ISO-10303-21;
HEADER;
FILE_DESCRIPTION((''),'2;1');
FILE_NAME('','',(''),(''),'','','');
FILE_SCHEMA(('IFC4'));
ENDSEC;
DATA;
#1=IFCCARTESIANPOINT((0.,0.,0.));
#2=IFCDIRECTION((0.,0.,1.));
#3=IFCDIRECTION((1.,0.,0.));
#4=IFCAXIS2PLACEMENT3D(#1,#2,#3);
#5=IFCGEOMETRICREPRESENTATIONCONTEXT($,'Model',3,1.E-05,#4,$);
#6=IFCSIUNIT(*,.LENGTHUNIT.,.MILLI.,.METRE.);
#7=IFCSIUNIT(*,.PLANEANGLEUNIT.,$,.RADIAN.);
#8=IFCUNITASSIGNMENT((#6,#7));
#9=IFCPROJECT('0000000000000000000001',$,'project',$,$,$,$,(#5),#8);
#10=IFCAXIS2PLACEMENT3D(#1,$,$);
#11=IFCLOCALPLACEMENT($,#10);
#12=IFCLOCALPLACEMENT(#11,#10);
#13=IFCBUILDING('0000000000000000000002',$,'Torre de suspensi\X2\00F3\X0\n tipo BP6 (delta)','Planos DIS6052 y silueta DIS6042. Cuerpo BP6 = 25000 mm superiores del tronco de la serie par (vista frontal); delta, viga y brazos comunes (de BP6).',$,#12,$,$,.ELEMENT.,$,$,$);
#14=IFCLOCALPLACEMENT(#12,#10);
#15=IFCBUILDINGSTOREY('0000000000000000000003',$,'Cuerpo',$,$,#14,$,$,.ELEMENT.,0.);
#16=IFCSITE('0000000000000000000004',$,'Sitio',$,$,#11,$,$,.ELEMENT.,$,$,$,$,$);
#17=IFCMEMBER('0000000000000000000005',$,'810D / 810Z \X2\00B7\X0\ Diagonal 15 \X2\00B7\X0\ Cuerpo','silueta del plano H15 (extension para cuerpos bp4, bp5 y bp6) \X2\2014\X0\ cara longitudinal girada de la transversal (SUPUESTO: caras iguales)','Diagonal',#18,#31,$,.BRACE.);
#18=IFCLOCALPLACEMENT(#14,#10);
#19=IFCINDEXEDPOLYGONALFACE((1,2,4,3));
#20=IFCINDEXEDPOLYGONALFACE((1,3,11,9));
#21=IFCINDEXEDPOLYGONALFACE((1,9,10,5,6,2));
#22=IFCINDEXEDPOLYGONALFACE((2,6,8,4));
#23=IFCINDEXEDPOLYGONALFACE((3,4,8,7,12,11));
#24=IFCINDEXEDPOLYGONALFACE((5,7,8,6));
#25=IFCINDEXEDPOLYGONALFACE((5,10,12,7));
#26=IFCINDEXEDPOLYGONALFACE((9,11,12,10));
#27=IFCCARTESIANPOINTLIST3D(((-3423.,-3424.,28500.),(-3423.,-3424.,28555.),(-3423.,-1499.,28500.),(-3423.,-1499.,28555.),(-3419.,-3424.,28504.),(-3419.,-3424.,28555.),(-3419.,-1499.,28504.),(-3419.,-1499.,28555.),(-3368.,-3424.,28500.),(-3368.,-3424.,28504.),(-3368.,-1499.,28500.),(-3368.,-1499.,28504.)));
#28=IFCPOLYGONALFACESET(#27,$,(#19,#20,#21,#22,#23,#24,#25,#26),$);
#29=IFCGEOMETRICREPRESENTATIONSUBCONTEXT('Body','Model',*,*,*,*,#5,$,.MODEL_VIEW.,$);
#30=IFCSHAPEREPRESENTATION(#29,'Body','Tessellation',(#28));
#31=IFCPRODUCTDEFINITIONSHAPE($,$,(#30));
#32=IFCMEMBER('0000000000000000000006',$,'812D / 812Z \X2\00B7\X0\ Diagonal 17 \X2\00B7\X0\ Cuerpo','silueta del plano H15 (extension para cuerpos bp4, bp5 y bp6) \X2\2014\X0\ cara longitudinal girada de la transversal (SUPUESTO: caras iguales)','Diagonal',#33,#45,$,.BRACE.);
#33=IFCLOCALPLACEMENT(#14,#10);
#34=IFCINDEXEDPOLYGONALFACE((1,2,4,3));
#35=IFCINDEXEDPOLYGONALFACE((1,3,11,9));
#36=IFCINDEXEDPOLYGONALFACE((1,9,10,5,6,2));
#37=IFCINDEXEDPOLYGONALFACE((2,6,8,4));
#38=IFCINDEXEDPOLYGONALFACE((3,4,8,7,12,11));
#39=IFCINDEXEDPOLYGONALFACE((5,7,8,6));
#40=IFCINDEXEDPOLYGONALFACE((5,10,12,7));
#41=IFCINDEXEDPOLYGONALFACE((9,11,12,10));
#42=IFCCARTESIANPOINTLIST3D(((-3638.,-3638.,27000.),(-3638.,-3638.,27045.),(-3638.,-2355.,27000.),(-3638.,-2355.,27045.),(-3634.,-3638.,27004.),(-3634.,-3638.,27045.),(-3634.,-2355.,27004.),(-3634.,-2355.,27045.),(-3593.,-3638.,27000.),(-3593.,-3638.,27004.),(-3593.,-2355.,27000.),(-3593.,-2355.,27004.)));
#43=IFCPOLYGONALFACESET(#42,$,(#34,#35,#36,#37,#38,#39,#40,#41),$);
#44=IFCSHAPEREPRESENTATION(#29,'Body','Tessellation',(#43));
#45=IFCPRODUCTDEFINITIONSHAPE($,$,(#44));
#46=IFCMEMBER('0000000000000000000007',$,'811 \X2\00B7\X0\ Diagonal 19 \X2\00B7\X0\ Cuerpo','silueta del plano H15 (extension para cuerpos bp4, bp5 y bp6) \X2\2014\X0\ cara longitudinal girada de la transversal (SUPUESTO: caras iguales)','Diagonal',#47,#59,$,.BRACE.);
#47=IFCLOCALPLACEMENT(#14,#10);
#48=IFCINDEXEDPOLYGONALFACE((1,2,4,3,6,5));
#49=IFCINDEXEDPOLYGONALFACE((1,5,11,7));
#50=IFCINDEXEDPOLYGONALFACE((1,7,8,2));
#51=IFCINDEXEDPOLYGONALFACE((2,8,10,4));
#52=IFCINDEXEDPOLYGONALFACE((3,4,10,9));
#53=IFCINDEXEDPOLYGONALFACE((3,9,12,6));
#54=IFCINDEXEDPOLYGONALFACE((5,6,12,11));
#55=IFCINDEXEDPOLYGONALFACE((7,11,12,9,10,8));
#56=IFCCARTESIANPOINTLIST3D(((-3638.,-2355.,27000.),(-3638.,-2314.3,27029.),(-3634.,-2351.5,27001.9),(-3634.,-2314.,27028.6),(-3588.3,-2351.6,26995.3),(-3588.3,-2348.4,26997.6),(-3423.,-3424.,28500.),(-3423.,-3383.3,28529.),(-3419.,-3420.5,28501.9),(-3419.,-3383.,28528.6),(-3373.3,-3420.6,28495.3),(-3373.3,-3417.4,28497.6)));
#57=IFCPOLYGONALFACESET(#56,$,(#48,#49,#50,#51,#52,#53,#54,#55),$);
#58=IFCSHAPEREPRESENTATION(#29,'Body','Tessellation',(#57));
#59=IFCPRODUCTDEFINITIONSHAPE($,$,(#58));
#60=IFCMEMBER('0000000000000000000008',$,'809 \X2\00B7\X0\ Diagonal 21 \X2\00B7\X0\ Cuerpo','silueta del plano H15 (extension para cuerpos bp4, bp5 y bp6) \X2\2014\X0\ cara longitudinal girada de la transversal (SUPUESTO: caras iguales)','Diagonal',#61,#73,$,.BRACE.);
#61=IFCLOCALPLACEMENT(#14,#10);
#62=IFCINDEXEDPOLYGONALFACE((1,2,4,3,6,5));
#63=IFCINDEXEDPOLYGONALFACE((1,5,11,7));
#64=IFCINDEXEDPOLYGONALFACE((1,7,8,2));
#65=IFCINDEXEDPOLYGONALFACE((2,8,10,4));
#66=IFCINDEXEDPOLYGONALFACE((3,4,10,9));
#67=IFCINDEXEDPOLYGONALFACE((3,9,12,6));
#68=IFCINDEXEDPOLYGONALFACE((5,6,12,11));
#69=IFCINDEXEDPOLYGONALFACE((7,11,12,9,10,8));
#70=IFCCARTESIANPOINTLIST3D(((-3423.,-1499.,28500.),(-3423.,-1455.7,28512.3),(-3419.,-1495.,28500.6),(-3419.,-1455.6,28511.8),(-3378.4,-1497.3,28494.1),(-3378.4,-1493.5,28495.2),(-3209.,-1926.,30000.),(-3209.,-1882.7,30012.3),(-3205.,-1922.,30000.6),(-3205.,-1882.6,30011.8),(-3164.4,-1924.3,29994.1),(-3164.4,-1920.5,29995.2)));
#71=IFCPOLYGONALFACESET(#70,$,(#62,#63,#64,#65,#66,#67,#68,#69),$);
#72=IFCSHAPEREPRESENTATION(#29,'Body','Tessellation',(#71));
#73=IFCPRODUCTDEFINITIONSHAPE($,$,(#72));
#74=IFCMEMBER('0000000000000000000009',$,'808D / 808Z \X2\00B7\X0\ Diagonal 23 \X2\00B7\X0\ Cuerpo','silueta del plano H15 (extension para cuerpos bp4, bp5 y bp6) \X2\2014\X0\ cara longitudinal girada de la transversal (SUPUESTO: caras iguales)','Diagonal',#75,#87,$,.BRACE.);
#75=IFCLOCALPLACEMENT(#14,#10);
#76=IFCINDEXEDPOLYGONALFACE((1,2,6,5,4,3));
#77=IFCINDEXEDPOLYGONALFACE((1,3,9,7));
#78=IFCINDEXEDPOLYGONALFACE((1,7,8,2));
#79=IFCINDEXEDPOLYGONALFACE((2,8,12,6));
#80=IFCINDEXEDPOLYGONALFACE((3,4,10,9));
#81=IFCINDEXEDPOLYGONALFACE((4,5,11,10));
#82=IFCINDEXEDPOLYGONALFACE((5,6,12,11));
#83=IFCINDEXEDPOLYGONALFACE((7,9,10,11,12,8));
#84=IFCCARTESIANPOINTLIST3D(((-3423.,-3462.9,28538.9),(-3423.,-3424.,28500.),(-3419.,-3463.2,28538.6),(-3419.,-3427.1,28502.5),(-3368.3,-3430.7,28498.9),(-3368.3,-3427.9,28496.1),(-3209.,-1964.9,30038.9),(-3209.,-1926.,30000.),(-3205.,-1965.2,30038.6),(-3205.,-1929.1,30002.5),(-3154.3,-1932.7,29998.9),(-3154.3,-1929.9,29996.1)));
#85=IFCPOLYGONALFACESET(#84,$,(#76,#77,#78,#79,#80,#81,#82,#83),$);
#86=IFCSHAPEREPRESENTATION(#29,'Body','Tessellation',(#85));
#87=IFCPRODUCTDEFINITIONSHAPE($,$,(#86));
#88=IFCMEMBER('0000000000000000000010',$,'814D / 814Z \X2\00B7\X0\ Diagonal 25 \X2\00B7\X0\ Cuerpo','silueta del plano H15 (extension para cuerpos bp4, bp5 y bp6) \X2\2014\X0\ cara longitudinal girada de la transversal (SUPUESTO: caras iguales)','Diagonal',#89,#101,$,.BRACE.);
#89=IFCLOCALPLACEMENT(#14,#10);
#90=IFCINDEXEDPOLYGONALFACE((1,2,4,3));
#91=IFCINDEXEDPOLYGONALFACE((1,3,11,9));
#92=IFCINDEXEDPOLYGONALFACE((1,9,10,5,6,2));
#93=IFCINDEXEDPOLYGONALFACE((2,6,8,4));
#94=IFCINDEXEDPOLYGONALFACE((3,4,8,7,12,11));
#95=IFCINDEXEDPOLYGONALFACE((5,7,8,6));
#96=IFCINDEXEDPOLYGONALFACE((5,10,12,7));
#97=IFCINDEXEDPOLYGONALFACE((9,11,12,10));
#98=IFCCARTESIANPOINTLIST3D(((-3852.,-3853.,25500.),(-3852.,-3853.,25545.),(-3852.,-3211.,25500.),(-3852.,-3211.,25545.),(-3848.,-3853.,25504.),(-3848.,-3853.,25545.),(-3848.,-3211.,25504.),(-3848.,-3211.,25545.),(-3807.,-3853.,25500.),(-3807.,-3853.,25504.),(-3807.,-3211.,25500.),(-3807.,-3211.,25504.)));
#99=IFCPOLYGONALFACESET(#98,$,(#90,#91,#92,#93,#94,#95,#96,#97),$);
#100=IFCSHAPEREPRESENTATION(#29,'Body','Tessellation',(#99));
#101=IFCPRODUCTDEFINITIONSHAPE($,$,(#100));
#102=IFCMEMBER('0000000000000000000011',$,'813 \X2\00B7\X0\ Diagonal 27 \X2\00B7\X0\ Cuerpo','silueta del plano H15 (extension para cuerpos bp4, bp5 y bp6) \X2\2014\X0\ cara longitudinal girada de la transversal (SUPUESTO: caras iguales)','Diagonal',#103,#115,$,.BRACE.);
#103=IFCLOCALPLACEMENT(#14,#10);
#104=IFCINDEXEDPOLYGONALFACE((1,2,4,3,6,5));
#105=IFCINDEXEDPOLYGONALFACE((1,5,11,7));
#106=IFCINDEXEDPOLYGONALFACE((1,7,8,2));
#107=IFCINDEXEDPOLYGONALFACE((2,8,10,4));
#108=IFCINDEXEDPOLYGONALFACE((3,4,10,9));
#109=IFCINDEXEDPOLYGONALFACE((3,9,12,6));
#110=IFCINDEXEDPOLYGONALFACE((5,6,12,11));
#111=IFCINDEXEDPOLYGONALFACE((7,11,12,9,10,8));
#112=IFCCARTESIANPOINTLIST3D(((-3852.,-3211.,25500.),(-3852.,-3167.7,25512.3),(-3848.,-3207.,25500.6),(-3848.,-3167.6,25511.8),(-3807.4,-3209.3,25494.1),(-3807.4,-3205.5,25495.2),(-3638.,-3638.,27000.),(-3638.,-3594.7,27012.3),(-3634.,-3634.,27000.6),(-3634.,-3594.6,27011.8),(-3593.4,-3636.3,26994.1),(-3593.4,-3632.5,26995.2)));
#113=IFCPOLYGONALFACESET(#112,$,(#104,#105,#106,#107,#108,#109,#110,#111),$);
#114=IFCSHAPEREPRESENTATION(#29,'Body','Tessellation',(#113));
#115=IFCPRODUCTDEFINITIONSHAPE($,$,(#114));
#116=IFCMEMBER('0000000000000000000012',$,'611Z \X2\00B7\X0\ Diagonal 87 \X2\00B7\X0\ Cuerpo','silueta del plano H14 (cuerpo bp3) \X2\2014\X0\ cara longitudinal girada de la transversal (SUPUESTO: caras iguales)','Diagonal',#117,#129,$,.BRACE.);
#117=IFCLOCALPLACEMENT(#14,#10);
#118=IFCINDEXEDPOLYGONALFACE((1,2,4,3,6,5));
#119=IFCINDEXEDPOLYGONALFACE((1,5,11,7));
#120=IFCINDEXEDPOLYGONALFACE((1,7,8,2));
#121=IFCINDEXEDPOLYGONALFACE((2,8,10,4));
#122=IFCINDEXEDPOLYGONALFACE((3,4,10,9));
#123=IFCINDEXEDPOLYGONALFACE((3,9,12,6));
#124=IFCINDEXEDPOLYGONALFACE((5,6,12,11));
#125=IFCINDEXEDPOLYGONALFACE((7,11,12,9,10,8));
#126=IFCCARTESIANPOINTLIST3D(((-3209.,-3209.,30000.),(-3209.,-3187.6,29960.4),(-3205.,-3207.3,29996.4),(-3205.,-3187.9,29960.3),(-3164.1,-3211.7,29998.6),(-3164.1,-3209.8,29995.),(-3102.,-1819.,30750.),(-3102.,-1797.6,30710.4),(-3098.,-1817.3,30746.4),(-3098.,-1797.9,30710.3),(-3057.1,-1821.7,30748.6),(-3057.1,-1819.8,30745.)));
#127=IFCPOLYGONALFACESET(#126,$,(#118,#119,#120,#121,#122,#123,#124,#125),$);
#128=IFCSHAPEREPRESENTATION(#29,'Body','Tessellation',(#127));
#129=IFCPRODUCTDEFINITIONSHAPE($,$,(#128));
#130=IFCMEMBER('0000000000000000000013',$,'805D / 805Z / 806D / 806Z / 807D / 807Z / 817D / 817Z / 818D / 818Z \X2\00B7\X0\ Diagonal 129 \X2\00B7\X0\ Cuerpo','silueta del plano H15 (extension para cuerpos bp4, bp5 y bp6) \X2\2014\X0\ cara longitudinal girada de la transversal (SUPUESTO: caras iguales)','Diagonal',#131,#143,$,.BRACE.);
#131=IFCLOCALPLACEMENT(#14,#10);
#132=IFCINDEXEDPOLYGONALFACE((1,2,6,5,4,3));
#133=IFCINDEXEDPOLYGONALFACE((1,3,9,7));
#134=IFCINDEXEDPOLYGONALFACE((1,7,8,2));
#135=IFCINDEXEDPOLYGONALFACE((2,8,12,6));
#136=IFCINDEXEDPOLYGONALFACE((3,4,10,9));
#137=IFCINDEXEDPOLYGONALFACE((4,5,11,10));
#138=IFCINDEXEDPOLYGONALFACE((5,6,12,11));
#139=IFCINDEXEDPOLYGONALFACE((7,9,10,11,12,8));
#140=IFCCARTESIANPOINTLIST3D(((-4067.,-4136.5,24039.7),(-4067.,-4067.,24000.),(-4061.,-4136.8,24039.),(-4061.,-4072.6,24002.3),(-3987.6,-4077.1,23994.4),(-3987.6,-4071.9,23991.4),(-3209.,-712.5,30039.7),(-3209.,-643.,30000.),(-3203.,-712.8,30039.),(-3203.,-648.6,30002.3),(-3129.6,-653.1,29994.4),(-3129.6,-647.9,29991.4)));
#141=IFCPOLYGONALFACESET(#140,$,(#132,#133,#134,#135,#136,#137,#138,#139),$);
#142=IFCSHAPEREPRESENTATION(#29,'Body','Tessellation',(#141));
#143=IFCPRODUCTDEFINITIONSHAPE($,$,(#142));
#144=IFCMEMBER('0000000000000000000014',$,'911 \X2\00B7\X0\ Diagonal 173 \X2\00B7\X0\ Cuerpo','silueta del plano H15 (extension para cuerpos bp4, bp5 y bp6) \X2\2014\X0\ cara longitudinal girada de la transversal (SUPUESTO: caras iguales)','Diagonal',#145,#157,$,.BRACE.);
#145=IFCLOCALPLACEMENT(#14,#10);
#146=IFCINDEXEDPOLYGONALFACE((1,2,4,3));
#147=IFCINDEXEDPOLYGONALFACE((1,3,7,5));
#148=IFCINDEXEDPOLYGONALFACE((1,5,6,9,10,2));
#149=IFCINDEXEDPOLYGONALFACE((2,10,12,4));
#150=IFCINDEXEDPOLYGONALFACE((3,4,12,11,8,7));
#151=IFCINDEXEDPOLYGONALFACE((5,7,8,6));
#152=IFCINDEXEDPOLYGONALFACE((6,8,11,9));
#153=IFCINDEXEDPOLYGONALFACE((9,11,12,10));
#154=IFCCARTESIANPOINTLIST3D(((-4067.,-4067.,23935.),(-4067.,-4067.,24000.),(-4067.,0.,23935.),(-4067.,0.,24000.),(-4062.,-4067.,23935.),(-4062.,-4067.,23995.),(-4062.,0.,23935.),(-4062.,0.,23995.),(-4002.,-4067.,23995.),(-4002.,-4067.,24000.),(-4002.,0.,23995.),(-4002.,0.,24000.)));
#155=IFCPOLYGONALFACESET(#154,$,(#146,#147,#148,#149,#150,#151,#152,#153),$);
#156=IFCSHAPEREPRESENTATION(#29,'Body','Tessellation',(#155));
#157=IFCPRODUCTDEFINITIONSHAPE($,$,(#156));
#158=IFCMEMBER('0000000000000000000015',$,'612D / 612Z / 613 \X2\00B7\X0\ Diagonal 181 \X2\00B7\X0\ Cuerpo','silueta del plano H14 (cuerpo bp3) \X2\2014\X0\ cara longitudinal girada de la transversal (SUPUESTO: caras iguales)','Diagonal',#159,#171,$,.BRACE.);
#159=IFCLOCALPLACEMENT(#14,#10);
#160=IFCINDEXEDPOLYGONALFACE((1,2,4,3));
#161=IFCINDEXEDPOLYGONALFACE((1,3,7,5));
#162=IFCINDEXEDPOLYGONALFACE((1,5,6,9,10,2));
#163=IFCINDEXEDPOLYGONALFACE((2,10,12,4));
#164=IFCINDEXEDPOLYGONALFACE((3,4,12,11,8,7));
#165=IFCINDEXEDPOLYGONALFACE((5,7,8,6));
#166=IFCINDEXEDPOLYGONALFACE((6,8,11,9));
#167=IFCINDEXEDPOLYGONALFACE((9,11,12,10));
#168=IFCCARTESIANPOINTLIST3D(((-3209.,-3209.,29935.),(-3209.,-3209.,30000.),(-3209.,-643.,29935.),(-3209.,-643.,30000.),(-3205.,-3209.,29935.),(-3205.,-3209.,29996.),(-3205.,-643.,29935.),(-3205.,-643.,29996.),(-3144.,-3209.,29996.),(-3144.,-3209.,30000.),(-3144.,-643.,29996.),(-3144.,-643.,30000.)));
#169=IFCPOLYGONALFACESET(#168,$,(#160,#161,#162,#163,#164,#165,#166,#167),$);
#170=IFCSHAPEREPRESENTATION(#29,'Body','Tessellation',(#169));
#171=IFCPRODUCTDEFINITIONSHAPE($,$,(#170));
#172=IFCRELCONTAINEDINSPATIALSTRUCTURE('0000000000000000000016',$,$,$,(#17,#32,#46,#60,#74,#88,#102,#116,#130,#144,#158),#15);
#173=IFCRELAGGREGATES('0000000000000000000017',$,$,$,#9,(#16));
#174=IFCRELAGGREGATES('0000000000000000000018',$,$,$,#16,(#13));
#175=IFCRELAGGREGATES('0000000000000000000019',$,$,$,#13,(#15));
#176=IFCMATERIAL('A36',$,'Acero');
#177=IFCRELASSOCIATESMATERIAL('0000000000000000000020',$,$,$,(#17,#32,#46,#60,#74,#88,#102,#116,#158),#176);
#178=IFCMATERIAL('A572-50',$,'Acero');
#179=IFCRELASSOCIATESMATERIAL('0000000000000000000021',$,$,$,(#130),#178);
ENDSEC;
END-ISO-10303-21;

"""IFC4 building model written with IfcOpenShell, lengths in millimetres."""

from ifc_helpers import new_model, si_unit, frame, frame_2d, origin, origin_with_axes, place, context, subcontext, project, spatial, l_section, extrude, material, element, save


model = new_model("IFC4")

# Units and contexts
model_context = context("Model", 3, precision=1e-05, world=origin_with_axes())
body_context = subcontext(model_context, "Body", "Model", "MODEL_VIEW")
ifc_project = project(units=[si_unit("LENGTHUNIT", "METRE", prefix="MILLI"), si_unit("PLANEANGLEUNIT", "RADIAN")], contexts=[model_context])

# Site, building, storey
site_placement = place(None, origin())
site = spatial("IfcSite", under=ifc_project, at=site_placement, Name="Sitio", CompositionType="ELEMENT")
building_placement = place(site_placement, origin())
building = spatial("IfcBuilding", under=site, at=building_placement, Name="Torre de suspensión tipo BP6 (delta)", Description="Planos DIS6052 y silueta DIS6042. Cuerpo BP6 = 25000 mm superiores del tronco de la serie par (vista frontal); delta, viga y brazos comunes (de BP6).", CompositionType="ELEMENT")
storey_placement = place(building_placement, origin())
storey = spatial("IfcBuildingStorey", under=building, at=storey_placement, Name="Cuerpo", CompositionType="ELEMENT", Elevation=0.0)

# Members
ifc_material_1 = material(Name="A36", Category="Acero")
ifc_material_2 = material(Name="A572-50", Category="Acero")
member_1_placement = place(storey_placement, frame((-3423.0, -1499.0, 28500.0), z_axis=(0.0, -1.0, 0.0), x_axis=(1.0, 0.0, 0.0)))
element("IfcMember", 1, at=member_1_placement, inside=storey, material=ifc_material_1, Name="810D / 810Z · Diagonal 15 · Cuerpo", Description="silueta del plano H15 (extension para cuerpos bp4, bp5 y bp6) — cara longitudinal girada de la transversal (SUPUESTO: caras iguales)", ObjectType="Diagonal", PredefinedType="BRACE", context=body_context, shape_type="SweptSolid", body=[
    extrude(l_section(Depth=55.0, Width=55.0, Thickness=4.0, at=frame_2d((27.5, 27.5))), None, (0.0, 0.0, 1.0), 1925.0),
])
member_2_placement = place(storey_placement, frame((-3638.0, -2355.0, 27000.0), z_axis=(0.0, -1.0, 0.0), x_axis=(1.0, 0.0, 0.0)))
element("IfcMember", 2, at=member_2_placement, inside=storey, material=ifc_material_1, Name="812D / 812Z · Diagonal 17 · Cuerpo", Description="silueta del plano H15 (extension para cuerpos bp4, bp5 y bp6) — cara longitudinal girada de la transversal (SUPUESTO: caras iguales)", ObjectType="Diagonal", PredefinedType="BRACE", context=body_context, shape_type="SweptSolid", body=[
    extrude(l_section(Depth=45.0, Width=45.0, Thickness=4.0, at=frame_2d((22.5, 22.5))), None, (0.0, 0.0, 1.0), 1283.0),
])
member_3_placement = place(storey_placement, frame((-3638.0, -2355.0, 27000.0), z_axis=(0.115937, -0.576451, 0.808865), x_axis=(0.993257, 0.067286, -0.094414)))
element("IfcMember", 3, at=member_3_placement, inside=storey, material=ifc_material_1, Name="811 · Diagonal 19 · Cuerpo", Description="silueta del plano H15 (extension para cuerpos bp4, bp5 y bp6) — cara longitudinal girada de la transversal (SUPUESTO: caras iguales)", ObjectType="Diagonal", PredefinedType="BRACE", context=body_context, shape_type="SweptSolid", body=[
    extrude(l_section(Depth=50.0, Width=50.0, Thickness=4.0, at=frame_2d((25.0, 25.0))), None, (0.0, 0.0, 1.0), 1854.5),
])
member_4_placement = place(storey_placement, frame((-3423.0, -1499.0, 28500.0), z_axis=(0.135942, -0.271248, 0.952861), x_axis=(0.990717, 0.037219, -0.130747)))
element("IfcMember", 4, at=member_4_placement, inside=storey, material=ifc_material_1, Name="809 · Diagonal 21 · Cuerpo", Description="silueta del plano H15 (extension para cuerpos bp4, bp5 y bp6) — cara longitudinal girada de la transversal (SUPUESTO: caras iguales)", ObjectType="Diagonal", PredefinedType="BRACE", context=body_context, shape_type="SweptSolid", body=[
    extrude(l_section(Depth=45.0, Width=45.0, Thickness=4.0, at=frame_2d((22.5, 22.5))), None, (0.0, 0.0, 1.0), 1574.2),
])
member_5_placement = place(storey_placement, frame((-3209.0, -1926.0, 30000.0), z_axis=(-0.100437, -0.703062, -0.704), x_axis=(0.994943, -0.070973, -0.071067)))
element("IfcMember", 5, at=member_5_placement, inside=storey, material=ifc_material_1, Name="808D / 808Z · Diagonal 23 · Cuerpo", Description="silueta del plano H15 (extension para cuerpos bp4, bp5 y bp6) — cara longitudinal girada de la transversal (SUPUESTO: caras iguales)", ObjectType="Diagonal", PredefinedType="BRACE", context=body_context, shape_type="SweptSolid", body=[
    extrude(l_section(Depth=55.0, Width=55.0, Thickness=4.0, at=frame_2d((27.5, 27.5))), None, (0.0, 0.0, 1.0), 2130.7),
])
member_6_placement = place(storey_placement, frame((-3852.0, -3211.0, 25500.0), z_axis=(0.0, -1.0, 0.0), x_axis=(1.0, 0.0, 0.0)))
element("IfcMember", 6, at=member_6_placement, inside=storey, material=ifc_material_1, Name="814D / 814Z · Diagonal 25 · Cuerpo", Description="silueta del plano H15 (extension para cuerpos bp4, bp5 y bp6) — cara longitudinal girada de la transversal (SUPUESTO: caras iguales)", ObjectType="Diagonal", PredefinedType="BRACE", context=body_context, shape_type="SweptSolid", body=[
    extrude(l_section(Depth=45.0, Width=45.0, Thickness=4.0, at=frame_2d((22.5, 22.5))), None, (0.0, 0.0, 1.0), 642.0),
])
member_7_placement = place(storey_placement, frame((-3852.0, -3211.0, 25500.0), z_axis=(0.135942, -0.271248, 0.952861), x_axis=(0.990717, 0.037219, -0.130747)))
element("IfcMember", 7, at=member_7_placement, inside=storey, material=ifc_material_1, Name="813 · Diagonal 27 · Cuerpo", Description="silueta del plano H15 (extension para cuerpos bp4, bp5 y bp6) — cara longitudinal girada de la transversal (SUPUESTO: caras iguales)", ObjectType="Diagonal", PredefinedType="BRACE", context=body_context, shape_type="SweptSolid", body=[
    extrude(l_section(Depth=45.0, Width=45.0, Thickness=4.0, at=frame_2d((22.5, 22.5))), None, (0.0, 0.0, 1.0), 1574.2),
])
member_8_placement = place(storey_placement, frame((-3209.0, -3209.0, 30000.0), z_axis=(0.067591, 0.878052, 0.473769), x_axis=(0.997713, -0.059484, -0.032096)))
element("IfcMember", 8, at=member_8_placement, inside=storey, material=ifc_material_1, Name="611Z · Diagonal 87 · Cuerpo", Description="silueta del plano H14 (cuerpo bp3) — cara longitudinal girada de la transversal (SUPUESTO: caras iguales)", ObjectType="Diagonal", PredefinedType="BRACE", context=body_context, shape_type="SweptSolid", body=[
    extrude(l_section(Depth=45.0, Width=45.0, Thickness=4.0, at=frame_2d((22.5, 22.5))), None, (0.0, 0.0, 1.0), 1583.1),
])
member_9_placement = place(storey_placement, frame((-3209.0, -643.0, 30000.0), z_axis=(-0.123253, -0.491861, -0.861906), x_axis=(0.992375, -0.061089, -0.107048)))
element("IfcMember", 9, at=member_9_placement, inside=storey, material=ifc_material_2, Name="805D / 805Z / 806D / 806Z / 807D / 807Z / 817D / 817Z / 818D / 818Z · Diagonal 129 · Cuerpo", Description="silueta del plano H15 (extension para cuerpos bp4, bp5 y bp6) — cara longitudinal girada de la transversal (SUPUESTO: caras iguales)", ObjectType="Diagonal", PredefinedType="BRACE", context=body_context, shape_type="SweptSolid", body=[
    extrude(l_section(Depth=80.0, Width=80.0, Thickness=6.0, at=frame_2d((40.0, 40.0))), None, (0.0, 0.0, 1.0), 6961.3),
])
member_10_placement = place(storey_placement, frame((-4067.0, -4067.0, 24000.0), z_axis=(0.0, 1.0, 0.0), x_axis=(1.0, 0.0, 0.0)))
element("IfcMember", 10, at=member_10_placement, inside=storey, Name="911 · Diagonal 173 · Cuerpo", Description="silueta del plano H15 (extension para cuerpos bp4, bp5 y bp6) — cara longitudinal girada de la transversal (SUPUESTO: caras iguales)", ObjectType="Diagonal", PredefinedType="BRACE", context=body_context, shape_type="SweptSolid", body=[
    extrude(l_section(Depth=65.0, Width=65.0, Thickness=5.0, at=frame_2d((32.5, 32.5))), None, (0.0, 0.0, 1.0), 4067.0),
])
member_11_placement = place(storey_placement, frame((-3209.0, -3209.0, 30000.0), z_axis=(0.0, 1.0, 0.0), x_axis=(1.0, 0.0, 0.0)))
element("IfcMember", 11, at=member_11_placement, inside=storey, material=ifc_material_1, Name="612D / 612Z / 613 · Diagonal 181 · Cuerpo", Description="silueta del plano H14 (cuerpo bp3) — cara longitudinal girada de la transversal (SUPUESTO: caras iguales)", ObjectType="Diagonal", PredefinedType="BRACE", context=body_context, shape_type="SweptSolid", body=[
    extrude(l_section(Depth=65.0, Width=65.0, Thickness=4.0, at=frame_2d((32.5, 32.5))), None, (0.0, 0.0, 1.0), 2566.0),
])

save(model, "model.ifc")
